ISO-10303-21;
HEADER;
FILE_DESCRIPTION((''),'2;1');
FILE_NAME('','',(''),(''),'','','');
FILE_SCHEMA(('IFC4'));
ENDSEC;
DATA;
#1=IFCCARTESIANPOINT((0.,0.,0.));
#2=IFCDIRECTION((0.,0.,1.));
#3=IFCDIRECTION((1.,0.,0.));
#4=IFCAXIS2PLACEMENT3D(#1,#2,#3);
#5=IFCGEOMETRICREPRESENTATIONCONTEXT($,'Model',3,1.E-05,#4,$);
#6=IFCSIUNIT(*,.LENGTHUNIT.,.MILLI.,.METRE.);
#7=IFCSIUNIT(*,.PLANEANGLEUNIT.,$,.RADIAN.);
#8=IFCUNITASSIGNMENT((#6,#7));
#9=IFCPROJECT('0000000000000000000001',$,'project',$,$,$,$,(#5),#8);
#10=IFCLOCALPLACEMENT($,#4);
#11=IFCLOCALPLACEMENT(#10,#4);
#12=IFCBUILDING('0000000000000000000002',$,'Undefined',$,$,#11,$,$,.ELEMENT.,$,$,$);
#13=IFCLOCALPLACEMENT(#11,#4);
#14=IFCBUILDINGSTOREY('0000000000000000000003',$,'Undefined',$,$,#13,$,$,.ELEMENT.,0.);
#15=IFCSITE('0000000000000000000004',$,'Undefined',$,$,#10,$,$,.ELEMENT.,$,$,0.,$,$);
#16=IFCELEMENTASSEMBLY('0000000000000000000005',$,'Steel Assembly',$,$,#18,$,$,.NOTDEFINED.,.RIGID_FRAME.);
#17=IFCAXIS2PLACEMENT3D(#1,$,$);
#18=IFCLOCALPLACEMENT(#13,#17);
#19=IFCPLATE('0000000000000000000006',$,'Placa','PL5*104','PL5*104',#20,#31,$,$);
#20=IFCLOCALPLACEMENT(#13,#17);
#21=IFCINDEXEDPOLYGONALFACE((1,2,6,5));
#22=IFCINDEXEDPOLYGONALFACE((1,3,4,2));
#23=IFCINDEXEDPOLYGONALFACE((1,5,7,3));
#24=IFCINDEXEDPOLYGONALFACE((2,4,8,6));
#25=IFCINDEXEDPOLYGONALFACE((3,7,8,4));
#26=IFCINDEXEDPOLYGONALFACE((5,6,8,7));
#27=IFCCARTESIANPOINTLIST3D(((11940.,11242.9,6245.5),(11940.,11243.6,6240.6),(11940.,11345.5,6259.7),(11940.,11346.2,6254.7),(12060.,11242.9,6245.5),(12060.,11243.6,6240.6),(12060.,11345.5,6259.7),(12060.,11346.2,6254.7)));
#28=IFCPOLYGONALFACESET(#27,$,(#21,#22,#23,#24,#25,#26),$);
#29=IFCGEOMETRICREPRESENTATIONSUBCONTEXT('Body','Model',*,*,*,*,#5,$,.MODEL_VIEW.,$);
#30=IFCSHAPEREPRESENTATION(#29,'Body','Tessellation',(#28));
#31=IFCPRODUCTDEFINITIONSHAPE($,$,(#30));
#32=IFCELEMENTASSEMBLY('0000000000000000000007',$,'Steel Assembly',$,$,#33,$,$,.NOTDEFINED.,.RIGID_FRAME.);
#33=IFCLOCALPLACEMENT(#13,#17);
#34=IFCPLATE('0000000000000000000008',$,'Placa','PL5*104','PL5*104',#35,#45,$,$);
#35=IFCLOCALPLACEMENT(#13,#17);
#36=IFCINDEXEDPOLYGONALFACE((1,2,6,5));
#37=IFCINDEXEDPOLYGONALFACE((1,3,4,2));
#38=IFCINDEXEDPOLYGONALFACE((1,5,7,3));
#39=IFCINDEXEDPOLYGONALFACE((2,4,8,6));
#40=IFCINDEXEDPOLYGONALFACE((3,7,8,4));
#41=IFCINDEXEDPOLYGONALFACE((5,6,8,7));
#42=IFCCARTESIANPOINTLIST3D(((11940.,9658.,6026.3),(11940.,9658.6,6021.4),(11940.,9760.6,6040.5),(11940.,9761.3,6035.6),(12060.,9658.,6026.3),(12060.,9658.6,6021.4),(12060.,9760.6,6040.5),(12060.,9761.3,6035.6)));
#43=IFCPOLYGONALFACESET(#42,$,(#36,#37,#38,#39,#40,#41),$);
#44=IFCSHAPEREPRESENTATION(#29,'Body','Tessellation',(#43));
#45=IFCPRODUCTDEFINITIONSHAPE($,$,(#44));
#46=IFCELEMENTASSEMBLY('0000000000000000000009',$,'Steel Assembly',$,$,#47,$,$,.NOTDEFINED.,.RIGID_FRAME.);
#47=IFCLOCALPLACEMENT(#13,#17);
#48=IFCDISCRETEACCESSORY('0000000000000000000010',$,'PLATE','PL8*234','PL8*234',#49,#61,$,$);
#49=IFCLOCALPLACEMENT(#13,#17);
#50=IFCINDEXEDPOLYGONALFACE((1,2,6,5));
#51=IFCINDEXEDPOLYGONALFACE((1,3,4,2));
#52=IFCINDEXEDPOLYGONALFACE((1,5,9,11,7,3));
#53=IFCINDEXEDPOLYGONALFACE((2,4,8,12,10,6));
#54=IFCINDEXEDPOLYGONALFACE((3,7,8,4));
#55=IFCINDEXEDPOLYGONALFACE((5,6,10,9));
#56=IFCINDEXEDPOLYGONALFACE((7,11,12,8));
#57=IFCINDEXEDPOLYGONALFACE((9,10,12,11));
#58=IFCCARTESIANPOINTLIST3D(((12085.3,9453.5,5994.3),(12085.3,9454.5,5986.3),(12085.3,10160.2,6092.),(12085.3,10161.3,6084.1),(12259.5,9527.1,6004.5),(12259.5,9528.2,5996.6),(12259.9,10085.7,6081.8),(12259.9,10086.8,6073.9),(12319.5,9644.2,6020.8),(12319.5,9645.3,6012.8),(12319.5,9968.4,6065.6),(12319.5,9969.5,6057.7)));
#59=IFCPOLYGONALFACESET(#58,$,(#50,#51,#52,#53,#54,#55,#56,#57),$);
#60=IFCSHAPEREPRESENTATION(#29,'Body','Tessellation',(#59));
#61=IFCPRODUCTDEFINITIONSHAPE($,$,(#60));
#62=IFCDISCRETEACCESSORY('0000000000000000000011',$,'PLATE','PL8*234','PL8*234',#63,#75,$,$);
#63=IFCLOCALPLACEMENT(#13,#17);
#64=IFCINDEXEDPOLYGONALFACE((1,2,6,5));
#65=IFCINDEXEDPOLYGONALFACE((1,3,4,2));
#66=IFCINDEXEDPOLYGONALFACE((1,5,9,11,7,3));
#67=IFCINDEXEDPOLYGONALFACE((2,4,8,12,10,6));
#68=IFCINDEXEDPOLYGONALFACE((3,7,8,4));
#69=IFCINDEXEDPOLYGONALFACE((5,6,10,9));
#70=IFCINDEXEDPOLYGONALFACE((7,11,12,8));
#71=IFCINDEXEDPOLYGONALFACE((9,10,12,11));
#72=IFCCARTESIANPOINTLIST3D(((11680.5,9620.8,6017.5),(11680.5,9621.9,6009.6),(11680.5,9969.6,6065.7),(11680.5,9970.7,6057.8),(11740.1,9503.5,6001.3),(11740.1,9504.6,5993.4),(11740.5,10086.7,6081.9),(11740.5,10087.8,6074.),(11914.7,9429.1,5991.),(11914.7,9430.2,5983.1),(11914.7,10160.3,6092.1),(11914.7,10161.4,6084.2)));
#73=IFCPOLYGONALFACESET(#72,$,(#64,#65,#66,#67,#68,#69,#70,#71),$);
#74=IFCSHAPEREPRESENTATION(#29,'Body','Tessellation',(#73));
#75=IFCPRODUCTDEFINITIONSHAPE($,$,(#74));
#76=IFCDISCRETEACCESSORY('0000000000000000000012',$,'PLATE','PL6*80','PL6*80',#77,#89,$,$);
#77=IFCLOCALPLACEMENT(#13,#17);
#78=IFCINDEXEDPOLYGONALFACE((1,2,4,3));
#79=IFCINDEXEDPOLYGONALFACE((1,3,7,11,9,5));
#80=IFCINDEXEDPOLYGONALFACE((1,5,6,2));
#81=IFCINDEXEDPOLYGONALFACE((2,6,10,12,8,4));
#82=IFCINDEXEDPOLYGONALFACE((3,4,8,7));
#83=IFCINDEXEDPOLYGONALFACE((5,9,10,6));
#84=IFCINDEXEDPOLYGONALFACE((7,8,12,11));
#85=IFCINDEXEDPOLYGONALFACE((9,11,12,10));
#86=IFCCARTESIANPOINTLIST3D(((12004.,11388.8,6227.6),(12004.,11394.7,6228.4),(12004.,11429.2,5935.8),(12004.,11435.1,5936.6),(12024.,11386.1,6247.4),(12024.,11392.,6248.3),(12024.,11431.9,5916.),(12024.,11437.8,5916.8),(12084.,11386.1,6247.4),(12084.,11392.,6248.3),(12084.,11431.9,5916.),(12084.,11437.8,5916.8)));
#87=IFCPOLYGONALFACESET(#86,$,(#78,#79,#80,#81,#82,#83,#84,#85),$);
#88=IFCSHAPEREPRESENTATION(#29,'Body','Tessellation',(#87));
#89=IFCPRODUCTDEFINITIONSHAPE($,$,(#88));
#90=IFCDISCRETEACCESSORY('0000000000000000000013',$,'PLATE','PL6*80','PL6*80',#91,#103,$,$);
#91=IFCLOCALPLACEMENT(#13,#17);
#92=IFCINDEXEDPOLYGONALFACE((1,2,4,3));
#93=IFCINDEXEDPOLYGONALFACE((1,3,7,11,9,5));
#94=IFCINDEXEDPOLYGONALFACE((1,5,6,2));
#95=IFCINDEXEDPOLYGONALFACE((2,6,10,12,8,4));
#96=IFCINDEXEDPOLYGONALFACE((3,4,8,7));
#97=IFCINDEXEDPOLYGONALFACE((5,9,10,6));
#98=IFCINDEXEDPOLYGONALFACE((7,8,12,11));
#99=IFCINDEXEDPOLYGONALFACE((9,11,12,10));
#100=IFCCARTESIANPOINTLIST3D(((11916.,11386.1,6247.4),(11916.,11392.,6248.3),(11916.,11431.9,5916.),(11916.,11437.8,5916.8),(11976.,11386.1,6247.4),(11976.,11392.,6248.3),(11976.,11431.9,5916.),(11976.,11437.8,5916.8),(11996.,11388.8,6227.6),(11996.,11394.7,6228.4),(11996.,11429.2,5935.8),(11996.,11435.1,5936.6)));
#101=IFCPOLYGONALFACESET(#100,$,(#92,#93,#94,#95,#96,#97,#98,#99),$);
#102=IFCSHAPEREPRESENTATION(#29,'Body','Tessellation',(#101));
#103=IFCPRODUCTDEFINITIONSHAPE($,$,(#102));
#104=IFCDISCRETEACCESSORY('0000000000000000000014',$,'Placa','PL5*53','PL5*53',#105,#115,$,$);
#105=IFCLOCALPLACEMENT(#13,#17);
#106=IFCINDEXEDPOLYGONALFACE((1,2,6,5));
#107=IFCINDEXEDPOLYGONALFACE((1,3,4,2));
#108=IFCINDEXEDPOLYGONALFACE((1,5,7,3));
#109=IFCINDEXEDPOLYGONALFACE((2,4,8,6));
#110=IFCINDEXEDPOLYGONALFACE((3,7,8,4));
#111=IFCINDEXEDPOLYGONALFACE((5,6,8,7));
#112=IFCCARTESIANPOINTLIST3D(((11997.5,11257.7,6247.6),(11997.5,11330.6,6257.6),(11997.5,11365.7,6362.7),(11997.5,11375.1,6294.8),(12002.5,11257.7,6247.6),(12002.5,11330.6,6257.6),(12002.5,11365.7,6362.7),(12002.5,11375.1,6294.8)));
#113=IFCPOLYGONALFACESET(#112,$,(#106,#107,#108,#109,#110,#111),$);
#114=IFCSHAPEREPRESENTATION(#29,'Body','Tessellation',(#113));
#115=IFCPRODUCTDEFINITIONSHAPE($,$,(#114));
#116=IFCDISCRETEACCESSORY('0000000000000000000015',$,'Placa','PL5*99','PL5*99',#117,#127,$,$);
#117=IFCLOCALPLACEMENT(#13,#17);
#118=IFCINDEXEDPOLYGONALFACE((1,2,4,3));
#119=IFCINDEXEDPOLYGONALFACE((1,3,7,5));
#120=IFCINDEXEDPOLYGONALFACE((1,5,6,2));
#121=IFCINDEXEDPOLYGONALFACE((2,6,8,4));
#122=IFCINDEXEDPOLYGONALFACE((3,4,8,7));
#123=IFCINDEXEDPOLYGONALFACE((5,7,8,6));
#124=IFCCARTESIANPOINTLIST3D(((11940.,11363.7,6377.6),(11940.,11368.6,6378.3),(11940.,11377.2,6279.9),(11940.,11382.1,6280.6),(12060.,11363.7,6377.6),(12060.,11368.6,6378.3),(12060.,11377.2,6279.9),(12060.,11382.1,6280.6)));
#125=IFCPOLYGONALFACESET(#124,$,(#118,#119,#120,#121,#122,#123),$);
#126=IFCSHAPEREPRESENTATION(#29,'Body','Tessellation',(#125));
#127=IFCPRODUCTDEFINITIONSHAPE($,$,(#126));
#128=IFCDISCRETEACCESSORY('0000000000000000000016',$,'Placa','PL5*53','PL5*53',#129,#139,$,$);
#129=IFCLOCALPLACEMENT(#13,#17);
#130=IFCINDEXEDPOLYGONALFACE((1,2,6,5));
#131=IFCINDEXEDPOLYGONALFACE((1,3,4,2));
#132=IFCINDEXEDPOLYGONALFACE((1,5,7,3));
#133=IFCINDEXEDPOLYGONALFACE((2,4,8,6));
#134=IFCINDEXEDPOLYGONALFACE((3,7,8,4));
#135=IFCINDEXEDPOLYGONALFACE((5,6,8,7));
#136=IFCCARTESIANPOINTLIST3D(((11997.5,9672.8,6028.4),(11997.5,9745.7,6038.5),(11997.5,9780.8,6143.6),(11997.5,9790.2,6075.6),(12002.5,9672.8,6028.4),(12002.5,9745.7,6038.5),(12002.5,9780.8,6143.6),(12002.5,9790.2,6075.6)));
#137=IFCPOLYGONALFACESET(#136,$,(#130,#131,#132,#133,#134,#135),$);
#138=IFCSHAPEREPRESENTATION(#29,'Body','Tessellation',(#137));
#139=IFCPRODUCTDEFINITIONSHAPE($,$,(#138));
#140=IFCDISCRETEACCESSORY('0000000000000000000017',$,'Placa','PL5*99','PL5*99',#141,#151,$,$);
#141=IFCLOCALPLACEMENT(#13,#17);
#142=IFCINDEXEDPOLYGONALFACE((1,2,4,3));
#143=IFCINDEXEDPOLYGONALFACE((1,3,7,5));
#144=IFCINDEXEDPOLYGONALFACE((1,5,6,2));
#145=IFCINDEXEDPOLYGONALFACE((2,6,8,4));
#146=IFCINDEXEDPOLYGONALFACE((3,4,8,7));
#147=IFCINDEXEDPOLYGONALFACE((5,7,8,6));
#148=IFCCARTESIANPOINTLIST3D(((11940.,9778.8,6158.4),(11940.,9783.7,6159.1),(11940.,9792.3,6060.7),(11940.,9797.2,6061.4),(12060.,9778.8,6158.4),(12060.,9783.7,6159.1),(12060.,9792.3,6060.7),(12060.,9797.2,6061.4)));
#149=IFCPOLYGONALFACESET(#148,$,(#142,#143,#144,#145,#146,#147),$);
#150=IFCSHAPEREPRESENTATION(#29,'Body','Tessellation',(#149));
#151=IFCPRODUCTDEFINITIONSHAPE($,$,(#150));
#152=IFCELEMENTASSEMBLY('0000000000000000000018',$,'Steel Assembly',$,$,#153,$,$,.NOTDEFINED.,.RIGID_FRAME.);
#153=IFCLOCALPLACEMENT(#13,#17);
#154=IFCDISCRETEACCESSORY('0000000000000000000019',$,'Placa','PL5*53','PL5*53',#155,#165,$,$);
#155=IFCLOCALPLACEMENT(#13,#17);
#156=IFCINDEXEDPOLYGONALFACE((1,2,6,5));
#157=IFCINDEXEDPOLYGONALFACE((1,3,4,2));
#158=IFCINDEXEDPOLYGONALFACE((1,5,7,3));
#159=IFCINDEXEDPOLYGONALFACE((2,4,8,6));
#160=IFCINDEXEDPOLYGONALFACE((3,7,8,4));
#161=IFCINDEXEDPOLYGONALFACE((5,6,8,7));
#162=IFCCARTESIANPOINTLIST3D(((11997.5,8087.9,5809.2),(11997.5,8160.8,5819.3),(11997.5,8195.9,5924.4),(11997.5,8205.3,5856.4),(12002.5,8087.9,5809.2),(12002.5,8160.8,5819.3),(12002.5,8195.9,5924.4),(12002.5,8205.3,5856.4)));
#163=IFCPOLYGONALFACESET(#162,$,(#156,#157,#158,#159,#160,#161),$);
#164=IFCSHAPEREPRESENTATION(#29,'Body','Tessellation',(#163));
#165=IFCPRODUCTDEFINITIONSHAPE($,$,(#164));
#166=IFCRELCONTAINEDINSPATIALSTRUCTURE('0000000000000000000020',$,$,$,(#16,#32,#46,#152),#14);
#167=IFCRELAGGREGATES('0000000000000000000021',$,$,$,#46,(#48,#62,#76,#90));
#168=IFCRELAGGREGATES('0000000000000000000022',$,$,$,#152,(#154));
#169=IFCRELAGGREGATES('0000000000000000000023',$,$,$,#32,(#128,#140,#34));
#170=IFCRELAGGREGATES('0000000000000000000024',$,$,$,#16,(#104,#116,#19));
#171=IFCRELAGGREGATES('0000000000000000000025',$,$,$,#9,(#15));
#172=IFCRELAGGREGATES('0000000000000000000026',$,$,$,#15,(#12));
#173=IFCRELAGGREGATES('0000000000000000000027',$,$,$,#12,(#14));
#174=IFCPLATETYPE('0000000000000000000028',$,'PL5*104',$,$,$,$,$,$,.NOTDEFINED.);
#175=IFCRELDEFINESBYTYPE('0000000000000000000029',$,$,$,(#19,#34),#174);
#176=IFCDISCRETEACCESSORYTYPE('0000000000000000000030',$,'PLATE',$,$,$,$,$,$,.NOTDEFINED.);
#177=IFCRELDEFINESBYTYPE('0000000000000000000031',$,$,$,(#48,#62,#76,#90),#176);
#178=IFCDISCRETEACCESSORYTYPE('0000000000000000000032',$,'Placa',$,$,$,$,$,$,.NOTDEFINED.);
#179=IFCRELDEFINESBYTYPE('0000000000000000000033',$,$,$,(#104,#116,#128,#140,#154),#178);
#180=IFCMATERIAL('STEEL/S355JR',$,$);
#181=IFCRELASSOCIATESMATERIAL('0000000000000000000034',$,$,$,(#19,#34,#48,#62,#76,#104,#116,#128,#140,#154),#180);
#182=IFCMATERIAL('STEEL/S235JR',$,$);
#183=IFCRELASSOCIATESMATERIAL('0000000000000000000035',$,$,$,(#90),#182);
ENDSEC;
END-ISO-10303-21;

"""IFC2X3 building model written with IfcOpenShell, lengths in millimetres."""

from ifc_helpers import new_model, si_unit, frame, origin_with_axes, place, context, subcontext, project, spatial, polyline, outline, extrude, material, type_object, element, aggregate, save


model = new_model("IFC2X3")

# Units and contexts
model_context = context("Model", 3, precision=1e-05, world=origin_with_axes())
body_context = subcontext(model_context, "Body", "Model", "MODEL_VIEW")
ifc_project = project(units=[si_unit("LENGTHUNIT", "METRE", prefix="MILLI"), si_unit("PLANEANGLEUNIT", "RADIAN")], contexts=[model_context])

# Site, building, storey
site_placement = place(None, origin_with_axes())
site = spatial("IfcSite", under=ifc_project, at=site_placement, Name="Undefined", CompositionType="ELEMENT", RefElevation=0.0)
building_placement = place(site_placement, origin_with_axes())
building = spatial("IfcBuilding", under=site, at=building_placement, Name="Undefined", CompositionType="ELEMENT")
storey_placement = place(building_placement, origin_with_axes())
storey = spatial("IfcBuildingStorey", under=building, at=storey_placement, Name="Undefined", CompositionType="ELEMENT", Elevation=0.0)

# Shared definitions
ifc_material_1 = material(Name="STEEL/S355JR")

# Element assemblies, plates
assembly_1_placement = place(storey_placement, origin_with_axes())
assembly_1 = element("IfcElementAssembly", 1, at=assembly_1_placement, inside=storey, Name="Steel Assembly", AssemblyPlace="NOTDEFINED", PredefinedType="RIGID_FRAME")
plate_type_1 = type_object("IfcPlateType", Name="PL5*104", PredefinedType="NOTDEFINED")
plate_1_placement = place(assembly_1_placement, frame((11940.0, 11345.8, 6257.2), z_axis=(0.0, -0.136905, 0.990584), x_axis=(0.0, -0.990584, -0.136905)))
plate_1 = element("IfcPlate", 2, at=plate_1_placement, type_object=plate_type_1, material=ifc_material_1, Name="Placa", Description="PL5*104", ObjectType="PL5*104", context=body_context, shape_type="SweptSolid", body=[
    extrude(outline(polyline([(0.0, 0.0), (103.6, 0.0), (103.6, 120.0), (0.0, 120.0), (0.0, 0.0)])), frame((0.0, 0.0, -2.5), z_axis=(0.0, 0.0, 1.0), x_axis=(1.0, 0.0, 0.0)), (0.0, 0.0, 1.0), 5.0),
])
assembly_2_placement = place(storey_placement, origin_with_axes())
assembly_2 = element("IfcElementAssembly", 3, at=assembly_2_placement, inside=storey, Name="Steel Assembly", AssemblyPlace="NOTDEFINED", PredefinedType="RIGID_FRAME")
plate_2_placement = place(assembly_2_placement, frame((11940.0, 9760.9, 6038.0), z_axis=(0.0, -0.136905, 0.990584), x_axis=(0.0, -0.990584, -0.136905)))
plate_2 = element("IfcPlate", 4, at=plate_2_placement, type_object=plate_type_1, material=ifc_material_1, Name="Placa", Description="PL5*104", ObjectType="PL5*104", context=body_context, shape_type="SweptSolid", body=[
    extrude(outline(polyline([(0.0, 0.0), (103.6, 0.0), (103.6, 120.0), (0.0, 120.0), (0.0, 0.0)])), frame((0.0, 0.0, -2.5), z_axis=(0.0, 0.0, 1.0), x_axis=(1.0, 0.0, 0.0)), (0.0, 0.0, 1.0), 5.0),
])

# Element assembly, discrete accessories
assembly_3_placement = place(storey_placement, origin_with_axes())
assembly_3 = element("IfcElementAssembly", 5, at=assembly_3_placement, inside=storey, Name="Steel Assembly", AssemblyPlace="NOTDEFINED", PredefinedType="RIGID_FRAME")
discrete_accessory_type_1 = type_object("IfcDiscreteAccessoryType", Name="PLATE")
discrete_accessory_1_placement = place(assembly_3_placement, frame((12085.3, 10160.7, 6088.0), z_axis=(-0.000554, -0.13698, 0.990574), x_axis=(0.0, -0.990574, -0.13698)))
discrete_accessory_1 = element("IfcDiscreteAccessory", 6, at=discrete_accessory_1_placement, type_object=discrete_accessory_type_1, material=ifc_material_1, Name="PLATE", Description="PL8*234", ObjectType="PL8*234", context=body_context, shape_type="SweptSolid", body=[
    extrude(outline(polyline([(0.0, 0.0), (713.5, 0.0), (639.1, 174.2), (520.9, 234.3), (193.6, 234.3), (75.2, 174.6), (0.0, 0.0)])), frame((0.0, 0.0, -4.0), z_axis=(0.0, 0.0, 1.0), x_axis=(1.0, 0.0, 0.0)), (0.0, 0.0, 1.0), 8.0),
])
discrete_accessory_2_placement = place(assembly_3_placement, frame((11914.7, 9429.6, 5987.0), z_axis=(-0.000018, -0.13698, 0.990574), x_axis=(0.0, 0.990574, 0.13698)))
discrete_accessory_2 = element("IfcDiscreteAccessory", 7, at=discrete_accessory_2_placement, type_object=discrete_accessory_type_1, material=ifc_material_1, Name="PLATE", Description="PL8*234", ObjectType="PL8*234", context=body_context, shape_type="SweptSolid", body=[
    extrude(outline(polyline([(0.0, 0.0), (738.2, 0.0), (663.9, 174.2), (545.6, 234.3), (193.6, 234.3), (75.2, 174.6), (0.0, 0.0)])), frame((0.0, 0.0, -4.0), z_axis=(0.0, 0.0, 1.0), x_axis=(1.0, 0.0, 0.0)), (0.0, 0.0, 1.0), 8.0),
])
discrete_accessory_3_placement = place(assembly_3_placement, frame((12084.0, 11434.9, 5916.4), z_axis=(0.0, 0.990574, 0.13698), x_axis=(-1.0, 0.0, 0.0)))
discrete_accessory_3 = element("IfcDiscreteAccessory", 8, at=discrete_accessory_3_placement, type_object=discrete_accessory_type_1, material=ifc_material_1, Name="PLATE", Description="PL6*80", ObjectType="PL6*80", context=body_context, shape_type="SweptSolid", body=[
    extrude(outline(polyline([(0.0, 0.0), (60.0, 0.0), (80.0, 20.0), (80.0, 314.6), (60.0, 334.6), (0.0, 334.6), (0.0, 0.0)])), frame((0.0, 0.0, -3.0), z_axis=(0.0, 0.0, 1.0), x_axis=(1.0, 0.0, 0.0)), (0.0, 0.0, 1.0), 6.0),
])
ifc_material_2 = material(Name="STEEL/S235JR")
discrete_accessory_4_placement = place(assembly_3_placement, frame((11996.0, 11434.9, 5916.4), z_axis=(0.0, 0.990574, 0.13698), x_axis=(-1.0, 0.0, 0.0)))
discrete_accessory_4 = element("IfcDiscreteAccessory", 9, at=discrete_accessory_4_placement, type_object=discrete_accessory_type_1, material=ifc_material_2, Name="PLATE", Description="PL6*80", ObjectType="PL6*80", context=body_context, shape_type="SweptSolid", body=[
    extrude(outline(polyline([(0.0, 20.0), (20.0, 0.0), (80.0, 0.0), (80.0, 334.6), (20.0, 334.6), (0.0, 314.6), (0.0, 20.0)])), frame((0.0, 0.0, -3.0), z_axis=(0.0, 0.0, 1.0), x_axis=(1.0, 0.0, 0.0)), (0.0, 0.0, 1.0), 6.0),
])
aggregate(assembly_3, [discrete_accessory_1, discrete_accessory_2, discrete_accessory_3, discrete_accessory_4])

# Discrete accessories
discrete_accessory_type_2 = type_object("IfcDiscreteAccessoryType", Name="Placa")
discrete_accessory_5_placement = place(assembly_1_placement, frame((12000.0, 11365.7, 6362.7), z_axis=(1.0, 0.0, 0.0), x_axis=(0.0, -0.684057, -0.729429)))
discrete_accessory_5 = element("IfcDiscreteAccessory", 10, at=discrete_accessory_5_placement, type_object=discrete_accessory_type_2, material=ifc_material_1, Name="Placa", Description="PL5*53", ObjectType="PL5*53", context=body_context, shape_type="SweptSolid", body=[
    extrude(outline(polyline([(0.0, 0.0), (157.9, 0.0), (100.7, 46.3), (43.1, 53.3), (0.0, 0.0)])), frame((0.0, 0.0, -2.5), z_axis=(0.0, 0.0, 1.0), x_axis=(1.0, 0.0, 0.0)), (0.0, 0.0, 1.0), 5.0),
])
discrete_accessory_6_placement = place(assembly_1_placement, frame((11940.0, 11379.7, 6280.3), z_axis=(0.0, 0.990592, 0.136849), x_axis=(0.0, -0.136849, 0.990592)))
discrete_accessory_6 = element("IfcDiscreteAccessory", 11, at=discrete_accessory_6_placement, type_object=discrete_accessory_type_2, material=ifc_material_1, Name="Placa", Description="PL5*99", ObjectType="PL5*99", context=body_context, shape_type="SweptSolid", body=[
    extrude(outline(polyline([(0.0, 0.0), (98.6, 0.0), (98.6, 120.0), (0.0, 120.0), (0.0, 0.0)])), frame((0.0, 0.0, -2.5), z_axis=(0.0, 0.0, 1.0), x_axis=(1.0, 0.0, 0.0)), (0.0, 0.0, 1.0), 5.0),
])
discrete_accessory_7_placement = place(assembly_2_placement, frame((12000.0, 9780.8, 6143.6), z_axis=(1.0, 0.0, 0.0), x_axis=(0.0, -0.684057, -0.729429)))
discrete_accessory_7 = element("IfcDiscreteAccessory", 12, at=discrete_accessory_7_placement, type_object=discrete_accessory_type_2, material=ifc_material_1, Name="Placa", Description="PL5*53", ObjectType="PL5*53", context=body_context, shape_type="SweptSolid", body=[
    extrude(outline(polyline([(0.0, 0.0), (157.9, 0.0), (100.7, 46.3), (43.1, 53.3), (0.0, 0.0)])), frame((0.0, 0.0, -2.5), z_axis=(0.0, 0.0, 1.0), x_axis=(1.0, 0.0, 0.0)), (0.0, 0.0, 1.0), 5.0),
])
discrete_accessory_8_placement = place(assembly_2_placement, frame((11940.0, 9794.7, 6061.1), z_axis=(0.0, 0.990592, 0.136849), x_axis=(0.0, -0.136849, 0.990592)))
discrete_accessory_8 = element("IfcDiscreteAccessory", 13, at=discrete_accessory_8_placement, type_object=discrete_accessory_type_2, material=ifc_material_1, Name="Placa", Description="PL5*99", ObjectType="PL5*99", context=body_context, shape_type="SweptSolid", body=[
    extrude(outline(polyline([(0.0, 0.0), (98.6, 0.0), (98.6, 120.0), (0.0, 120.0), (0.0, 0.0)])), frame((0.0, 0.0, -2.5), z_axis=(0.0, 0.0, 1.0), x_axis=(1.0, 0.0, 0.0)), (0.0, 0.0, 1.0), 5.0),
])

# Element assembly, discrete accessory
assembly_4_placement = place(storey_placement, origin_with_axes())
assembly_4 = element("IfcElementAssembly", 14, at=assembly_4_placement, inside=storey, Name="Steel Assembly", AssemblyPlace="NOTDEFINED", PredefinedType="RIGID_FRAME")
discrete_accessory_9_placement = place(assembly_4_placement, frame((12000.0, 8195.9, 5924.4), z_axis=(1.0, 0.0, 0.0), x_axis=(0.0, -0.684057, -0.729429)))
discrete_accessory_9 = element("IfcDiscreteAccessory", 15, at=discrete_accessory_9_placement, type_object=discrete_accessory_type_2, material=ifc_material_1, Name="Placa", Description="PL5*53", ObjectType="PL5*53", context=body_context, shape_type="SweptSolid", body=[
    extrude(outline(polyline([(0.0, 0.0), (157.9, 0.0), (100.7, 46.3), (43.1, 53.3), (0.0, 0.0)])), frame((0.0, 0.0, -2.5), z_axis=(0.0, 0.0, 1.0), x_axis=(1.0, 0.0, 0.0)), (0.0, 0.0, 1.0), 5.0),
])

aggregate(assembly_4, [discrete_accessory_9])
aggregate(assembly_2, [discrete_accessory_7, discrete_accessory_8, plate_2])
aggregate(assembly_1, [discrete_accessory_5, discrete_accessory_6, plate_1])

save(model, "model.ifc")
